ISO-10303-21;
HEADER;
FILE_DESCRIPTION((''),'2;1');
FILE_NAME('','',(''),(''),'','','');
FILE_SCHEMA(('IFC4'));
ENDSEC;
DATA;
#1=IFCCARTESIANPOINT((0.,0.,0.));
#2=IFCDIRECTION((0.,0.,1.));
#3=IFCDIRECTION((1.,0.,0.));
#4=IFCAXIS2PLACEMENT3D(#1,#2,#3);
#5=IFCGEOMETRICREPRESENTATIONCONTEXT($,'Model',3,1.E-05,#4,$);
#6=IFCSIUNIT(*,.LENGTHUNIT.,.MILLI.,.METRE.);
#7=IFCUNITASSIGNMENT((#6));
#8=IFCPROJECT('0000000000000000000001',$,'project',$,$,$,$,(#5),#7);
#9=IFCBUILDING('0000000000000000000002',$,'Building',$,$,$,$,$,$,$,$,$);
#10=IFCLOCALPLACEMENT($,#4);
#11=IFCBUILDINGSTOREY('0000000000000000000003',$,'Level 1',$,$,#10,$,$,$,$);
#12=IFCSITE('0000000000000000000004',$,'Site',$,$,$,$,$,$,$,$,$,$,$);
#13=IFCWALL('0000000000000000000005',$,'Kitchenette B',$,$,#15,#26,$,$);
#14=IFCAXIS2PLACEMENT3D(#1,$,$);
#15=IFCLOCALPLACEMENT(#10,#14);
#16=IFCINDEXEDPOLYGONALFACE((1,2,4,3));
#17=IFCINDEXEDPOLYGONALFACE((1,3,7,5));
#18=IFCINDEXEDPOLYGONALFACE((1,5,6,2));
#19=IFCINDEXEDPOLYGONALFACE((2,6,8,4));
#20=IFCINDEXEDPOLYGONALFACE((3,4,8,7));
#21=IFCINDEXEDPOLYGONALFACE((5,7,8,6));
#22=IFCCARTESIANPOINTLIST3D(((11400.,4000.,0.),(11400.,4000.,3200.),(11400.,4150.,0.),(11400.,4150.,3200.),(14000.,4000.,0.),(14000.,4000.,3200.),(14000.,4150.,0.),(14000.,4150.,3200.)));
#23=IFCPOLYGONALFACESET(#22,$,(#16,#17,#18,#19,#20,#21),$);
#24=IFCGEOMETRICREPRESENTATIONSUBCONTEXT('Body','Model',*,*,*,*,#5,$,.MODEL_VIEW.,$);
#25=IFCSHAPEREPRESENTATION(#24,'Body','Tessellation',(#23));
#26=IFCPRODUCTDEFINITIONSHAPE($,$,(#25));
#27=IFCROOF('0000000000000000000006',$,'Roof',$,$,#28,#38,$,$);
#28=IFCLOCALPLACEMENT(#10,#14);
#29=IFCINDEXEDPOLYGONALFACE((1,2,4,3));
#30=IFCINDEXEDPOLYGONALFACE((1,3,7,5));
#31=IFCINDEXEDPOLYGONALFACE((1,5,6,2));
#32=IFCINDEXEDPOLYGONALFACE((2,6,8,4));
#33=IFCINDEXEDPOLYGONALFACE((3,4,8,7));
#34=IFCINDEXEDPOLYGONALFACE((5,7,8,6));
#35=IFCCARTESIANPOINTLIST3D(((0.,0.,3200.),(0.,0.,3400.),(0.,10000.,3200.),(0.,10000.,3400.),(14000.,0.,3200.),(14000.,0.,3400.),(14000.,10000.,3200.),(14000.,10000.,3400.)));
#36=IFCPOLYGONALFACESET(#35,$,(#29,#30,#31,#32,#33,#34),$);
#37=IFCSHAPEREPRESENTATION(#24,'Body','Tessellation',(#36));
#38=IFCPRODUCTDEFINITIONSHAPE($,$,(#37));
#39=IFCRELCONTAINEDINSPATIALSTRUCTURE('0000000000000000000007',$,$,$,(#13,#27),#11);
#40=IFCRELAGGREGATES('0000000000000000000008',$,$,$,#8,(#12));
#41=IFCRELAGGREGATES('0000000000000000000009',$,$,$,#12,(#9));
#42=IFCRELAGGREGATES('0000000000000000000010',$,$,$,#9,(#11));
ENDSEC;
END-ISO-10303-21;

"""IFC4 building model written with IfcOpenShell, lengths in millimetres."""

from ifc_helpers import new_model, si_unit, frame, origin_with_axes, place, context, subcontext, project, spatial, indexed_curve, outline, extrude, element, save


model = new_model("IFC4")

# Units and contexts
model_context = context("Model", 3, precision=1e-05, world=origin_with_axes())
body_context = subcontext(model_context, "Body", "Model", "MODEL_VIEW")
ifc_project = project(units=[si_unit("LENGTHUNIT", "METRE", prefix="MILLI")], contexts=[model_context])

# Site, building, storey
site = spatial("IfcSite", under=ifc_project, Name="Site")
building = spatial("IfcBuilding", under=site, Name="Building")
storey_placement = place(None, origin_with_axes())
storey = spatial("IfcBuildingStorey", under=building, at=storey_placement, Name="Level 1")

# Wall
wall_1_placement = place(storey_placement, frame((11400.0, 4000.0, 0.0), z_axis=(0.0, 0.0, 1.0), x_axis=(1.0, 0.0, 0.0)))
element("IfcWall", 1, at=wall_1_placement, inside=storey, Name="Kitchenette B", context=body_context, shape_type="SweptSolid", body=[
    extrude(outline(indexed_curve([(0.0, 0.0), (0.0, 150.0), (2600.0, 150.0), (2600.0, 0.0), (0.0, 0.0)], self_intersect=False)), origin_with_axes(), (0.0, 0.0, 1.0), 3200.0),
])

# Roof
roof_placement = place(storey_placement, frame((0.0, 0.0, 3200.0), z_axis=(0.0, 0.0, 1.0), x_axis=(1.0, 0.0, 0.0)))
element("IfcRoof", 2, at=roof_placement, inside=storey, Name="Roof", context=body_context, shape_type="SweptSolid", body=[
    extrude(outline(indexed_curve([(0.0, 0.0), (14000.0, 0.0), (14000.0, 10000.0), (0.0, 10000.0), (0.0, 0.0)])), None, (0.0, 0.0, 1.0), 200.0),
])

save(model, "model.ifc")
